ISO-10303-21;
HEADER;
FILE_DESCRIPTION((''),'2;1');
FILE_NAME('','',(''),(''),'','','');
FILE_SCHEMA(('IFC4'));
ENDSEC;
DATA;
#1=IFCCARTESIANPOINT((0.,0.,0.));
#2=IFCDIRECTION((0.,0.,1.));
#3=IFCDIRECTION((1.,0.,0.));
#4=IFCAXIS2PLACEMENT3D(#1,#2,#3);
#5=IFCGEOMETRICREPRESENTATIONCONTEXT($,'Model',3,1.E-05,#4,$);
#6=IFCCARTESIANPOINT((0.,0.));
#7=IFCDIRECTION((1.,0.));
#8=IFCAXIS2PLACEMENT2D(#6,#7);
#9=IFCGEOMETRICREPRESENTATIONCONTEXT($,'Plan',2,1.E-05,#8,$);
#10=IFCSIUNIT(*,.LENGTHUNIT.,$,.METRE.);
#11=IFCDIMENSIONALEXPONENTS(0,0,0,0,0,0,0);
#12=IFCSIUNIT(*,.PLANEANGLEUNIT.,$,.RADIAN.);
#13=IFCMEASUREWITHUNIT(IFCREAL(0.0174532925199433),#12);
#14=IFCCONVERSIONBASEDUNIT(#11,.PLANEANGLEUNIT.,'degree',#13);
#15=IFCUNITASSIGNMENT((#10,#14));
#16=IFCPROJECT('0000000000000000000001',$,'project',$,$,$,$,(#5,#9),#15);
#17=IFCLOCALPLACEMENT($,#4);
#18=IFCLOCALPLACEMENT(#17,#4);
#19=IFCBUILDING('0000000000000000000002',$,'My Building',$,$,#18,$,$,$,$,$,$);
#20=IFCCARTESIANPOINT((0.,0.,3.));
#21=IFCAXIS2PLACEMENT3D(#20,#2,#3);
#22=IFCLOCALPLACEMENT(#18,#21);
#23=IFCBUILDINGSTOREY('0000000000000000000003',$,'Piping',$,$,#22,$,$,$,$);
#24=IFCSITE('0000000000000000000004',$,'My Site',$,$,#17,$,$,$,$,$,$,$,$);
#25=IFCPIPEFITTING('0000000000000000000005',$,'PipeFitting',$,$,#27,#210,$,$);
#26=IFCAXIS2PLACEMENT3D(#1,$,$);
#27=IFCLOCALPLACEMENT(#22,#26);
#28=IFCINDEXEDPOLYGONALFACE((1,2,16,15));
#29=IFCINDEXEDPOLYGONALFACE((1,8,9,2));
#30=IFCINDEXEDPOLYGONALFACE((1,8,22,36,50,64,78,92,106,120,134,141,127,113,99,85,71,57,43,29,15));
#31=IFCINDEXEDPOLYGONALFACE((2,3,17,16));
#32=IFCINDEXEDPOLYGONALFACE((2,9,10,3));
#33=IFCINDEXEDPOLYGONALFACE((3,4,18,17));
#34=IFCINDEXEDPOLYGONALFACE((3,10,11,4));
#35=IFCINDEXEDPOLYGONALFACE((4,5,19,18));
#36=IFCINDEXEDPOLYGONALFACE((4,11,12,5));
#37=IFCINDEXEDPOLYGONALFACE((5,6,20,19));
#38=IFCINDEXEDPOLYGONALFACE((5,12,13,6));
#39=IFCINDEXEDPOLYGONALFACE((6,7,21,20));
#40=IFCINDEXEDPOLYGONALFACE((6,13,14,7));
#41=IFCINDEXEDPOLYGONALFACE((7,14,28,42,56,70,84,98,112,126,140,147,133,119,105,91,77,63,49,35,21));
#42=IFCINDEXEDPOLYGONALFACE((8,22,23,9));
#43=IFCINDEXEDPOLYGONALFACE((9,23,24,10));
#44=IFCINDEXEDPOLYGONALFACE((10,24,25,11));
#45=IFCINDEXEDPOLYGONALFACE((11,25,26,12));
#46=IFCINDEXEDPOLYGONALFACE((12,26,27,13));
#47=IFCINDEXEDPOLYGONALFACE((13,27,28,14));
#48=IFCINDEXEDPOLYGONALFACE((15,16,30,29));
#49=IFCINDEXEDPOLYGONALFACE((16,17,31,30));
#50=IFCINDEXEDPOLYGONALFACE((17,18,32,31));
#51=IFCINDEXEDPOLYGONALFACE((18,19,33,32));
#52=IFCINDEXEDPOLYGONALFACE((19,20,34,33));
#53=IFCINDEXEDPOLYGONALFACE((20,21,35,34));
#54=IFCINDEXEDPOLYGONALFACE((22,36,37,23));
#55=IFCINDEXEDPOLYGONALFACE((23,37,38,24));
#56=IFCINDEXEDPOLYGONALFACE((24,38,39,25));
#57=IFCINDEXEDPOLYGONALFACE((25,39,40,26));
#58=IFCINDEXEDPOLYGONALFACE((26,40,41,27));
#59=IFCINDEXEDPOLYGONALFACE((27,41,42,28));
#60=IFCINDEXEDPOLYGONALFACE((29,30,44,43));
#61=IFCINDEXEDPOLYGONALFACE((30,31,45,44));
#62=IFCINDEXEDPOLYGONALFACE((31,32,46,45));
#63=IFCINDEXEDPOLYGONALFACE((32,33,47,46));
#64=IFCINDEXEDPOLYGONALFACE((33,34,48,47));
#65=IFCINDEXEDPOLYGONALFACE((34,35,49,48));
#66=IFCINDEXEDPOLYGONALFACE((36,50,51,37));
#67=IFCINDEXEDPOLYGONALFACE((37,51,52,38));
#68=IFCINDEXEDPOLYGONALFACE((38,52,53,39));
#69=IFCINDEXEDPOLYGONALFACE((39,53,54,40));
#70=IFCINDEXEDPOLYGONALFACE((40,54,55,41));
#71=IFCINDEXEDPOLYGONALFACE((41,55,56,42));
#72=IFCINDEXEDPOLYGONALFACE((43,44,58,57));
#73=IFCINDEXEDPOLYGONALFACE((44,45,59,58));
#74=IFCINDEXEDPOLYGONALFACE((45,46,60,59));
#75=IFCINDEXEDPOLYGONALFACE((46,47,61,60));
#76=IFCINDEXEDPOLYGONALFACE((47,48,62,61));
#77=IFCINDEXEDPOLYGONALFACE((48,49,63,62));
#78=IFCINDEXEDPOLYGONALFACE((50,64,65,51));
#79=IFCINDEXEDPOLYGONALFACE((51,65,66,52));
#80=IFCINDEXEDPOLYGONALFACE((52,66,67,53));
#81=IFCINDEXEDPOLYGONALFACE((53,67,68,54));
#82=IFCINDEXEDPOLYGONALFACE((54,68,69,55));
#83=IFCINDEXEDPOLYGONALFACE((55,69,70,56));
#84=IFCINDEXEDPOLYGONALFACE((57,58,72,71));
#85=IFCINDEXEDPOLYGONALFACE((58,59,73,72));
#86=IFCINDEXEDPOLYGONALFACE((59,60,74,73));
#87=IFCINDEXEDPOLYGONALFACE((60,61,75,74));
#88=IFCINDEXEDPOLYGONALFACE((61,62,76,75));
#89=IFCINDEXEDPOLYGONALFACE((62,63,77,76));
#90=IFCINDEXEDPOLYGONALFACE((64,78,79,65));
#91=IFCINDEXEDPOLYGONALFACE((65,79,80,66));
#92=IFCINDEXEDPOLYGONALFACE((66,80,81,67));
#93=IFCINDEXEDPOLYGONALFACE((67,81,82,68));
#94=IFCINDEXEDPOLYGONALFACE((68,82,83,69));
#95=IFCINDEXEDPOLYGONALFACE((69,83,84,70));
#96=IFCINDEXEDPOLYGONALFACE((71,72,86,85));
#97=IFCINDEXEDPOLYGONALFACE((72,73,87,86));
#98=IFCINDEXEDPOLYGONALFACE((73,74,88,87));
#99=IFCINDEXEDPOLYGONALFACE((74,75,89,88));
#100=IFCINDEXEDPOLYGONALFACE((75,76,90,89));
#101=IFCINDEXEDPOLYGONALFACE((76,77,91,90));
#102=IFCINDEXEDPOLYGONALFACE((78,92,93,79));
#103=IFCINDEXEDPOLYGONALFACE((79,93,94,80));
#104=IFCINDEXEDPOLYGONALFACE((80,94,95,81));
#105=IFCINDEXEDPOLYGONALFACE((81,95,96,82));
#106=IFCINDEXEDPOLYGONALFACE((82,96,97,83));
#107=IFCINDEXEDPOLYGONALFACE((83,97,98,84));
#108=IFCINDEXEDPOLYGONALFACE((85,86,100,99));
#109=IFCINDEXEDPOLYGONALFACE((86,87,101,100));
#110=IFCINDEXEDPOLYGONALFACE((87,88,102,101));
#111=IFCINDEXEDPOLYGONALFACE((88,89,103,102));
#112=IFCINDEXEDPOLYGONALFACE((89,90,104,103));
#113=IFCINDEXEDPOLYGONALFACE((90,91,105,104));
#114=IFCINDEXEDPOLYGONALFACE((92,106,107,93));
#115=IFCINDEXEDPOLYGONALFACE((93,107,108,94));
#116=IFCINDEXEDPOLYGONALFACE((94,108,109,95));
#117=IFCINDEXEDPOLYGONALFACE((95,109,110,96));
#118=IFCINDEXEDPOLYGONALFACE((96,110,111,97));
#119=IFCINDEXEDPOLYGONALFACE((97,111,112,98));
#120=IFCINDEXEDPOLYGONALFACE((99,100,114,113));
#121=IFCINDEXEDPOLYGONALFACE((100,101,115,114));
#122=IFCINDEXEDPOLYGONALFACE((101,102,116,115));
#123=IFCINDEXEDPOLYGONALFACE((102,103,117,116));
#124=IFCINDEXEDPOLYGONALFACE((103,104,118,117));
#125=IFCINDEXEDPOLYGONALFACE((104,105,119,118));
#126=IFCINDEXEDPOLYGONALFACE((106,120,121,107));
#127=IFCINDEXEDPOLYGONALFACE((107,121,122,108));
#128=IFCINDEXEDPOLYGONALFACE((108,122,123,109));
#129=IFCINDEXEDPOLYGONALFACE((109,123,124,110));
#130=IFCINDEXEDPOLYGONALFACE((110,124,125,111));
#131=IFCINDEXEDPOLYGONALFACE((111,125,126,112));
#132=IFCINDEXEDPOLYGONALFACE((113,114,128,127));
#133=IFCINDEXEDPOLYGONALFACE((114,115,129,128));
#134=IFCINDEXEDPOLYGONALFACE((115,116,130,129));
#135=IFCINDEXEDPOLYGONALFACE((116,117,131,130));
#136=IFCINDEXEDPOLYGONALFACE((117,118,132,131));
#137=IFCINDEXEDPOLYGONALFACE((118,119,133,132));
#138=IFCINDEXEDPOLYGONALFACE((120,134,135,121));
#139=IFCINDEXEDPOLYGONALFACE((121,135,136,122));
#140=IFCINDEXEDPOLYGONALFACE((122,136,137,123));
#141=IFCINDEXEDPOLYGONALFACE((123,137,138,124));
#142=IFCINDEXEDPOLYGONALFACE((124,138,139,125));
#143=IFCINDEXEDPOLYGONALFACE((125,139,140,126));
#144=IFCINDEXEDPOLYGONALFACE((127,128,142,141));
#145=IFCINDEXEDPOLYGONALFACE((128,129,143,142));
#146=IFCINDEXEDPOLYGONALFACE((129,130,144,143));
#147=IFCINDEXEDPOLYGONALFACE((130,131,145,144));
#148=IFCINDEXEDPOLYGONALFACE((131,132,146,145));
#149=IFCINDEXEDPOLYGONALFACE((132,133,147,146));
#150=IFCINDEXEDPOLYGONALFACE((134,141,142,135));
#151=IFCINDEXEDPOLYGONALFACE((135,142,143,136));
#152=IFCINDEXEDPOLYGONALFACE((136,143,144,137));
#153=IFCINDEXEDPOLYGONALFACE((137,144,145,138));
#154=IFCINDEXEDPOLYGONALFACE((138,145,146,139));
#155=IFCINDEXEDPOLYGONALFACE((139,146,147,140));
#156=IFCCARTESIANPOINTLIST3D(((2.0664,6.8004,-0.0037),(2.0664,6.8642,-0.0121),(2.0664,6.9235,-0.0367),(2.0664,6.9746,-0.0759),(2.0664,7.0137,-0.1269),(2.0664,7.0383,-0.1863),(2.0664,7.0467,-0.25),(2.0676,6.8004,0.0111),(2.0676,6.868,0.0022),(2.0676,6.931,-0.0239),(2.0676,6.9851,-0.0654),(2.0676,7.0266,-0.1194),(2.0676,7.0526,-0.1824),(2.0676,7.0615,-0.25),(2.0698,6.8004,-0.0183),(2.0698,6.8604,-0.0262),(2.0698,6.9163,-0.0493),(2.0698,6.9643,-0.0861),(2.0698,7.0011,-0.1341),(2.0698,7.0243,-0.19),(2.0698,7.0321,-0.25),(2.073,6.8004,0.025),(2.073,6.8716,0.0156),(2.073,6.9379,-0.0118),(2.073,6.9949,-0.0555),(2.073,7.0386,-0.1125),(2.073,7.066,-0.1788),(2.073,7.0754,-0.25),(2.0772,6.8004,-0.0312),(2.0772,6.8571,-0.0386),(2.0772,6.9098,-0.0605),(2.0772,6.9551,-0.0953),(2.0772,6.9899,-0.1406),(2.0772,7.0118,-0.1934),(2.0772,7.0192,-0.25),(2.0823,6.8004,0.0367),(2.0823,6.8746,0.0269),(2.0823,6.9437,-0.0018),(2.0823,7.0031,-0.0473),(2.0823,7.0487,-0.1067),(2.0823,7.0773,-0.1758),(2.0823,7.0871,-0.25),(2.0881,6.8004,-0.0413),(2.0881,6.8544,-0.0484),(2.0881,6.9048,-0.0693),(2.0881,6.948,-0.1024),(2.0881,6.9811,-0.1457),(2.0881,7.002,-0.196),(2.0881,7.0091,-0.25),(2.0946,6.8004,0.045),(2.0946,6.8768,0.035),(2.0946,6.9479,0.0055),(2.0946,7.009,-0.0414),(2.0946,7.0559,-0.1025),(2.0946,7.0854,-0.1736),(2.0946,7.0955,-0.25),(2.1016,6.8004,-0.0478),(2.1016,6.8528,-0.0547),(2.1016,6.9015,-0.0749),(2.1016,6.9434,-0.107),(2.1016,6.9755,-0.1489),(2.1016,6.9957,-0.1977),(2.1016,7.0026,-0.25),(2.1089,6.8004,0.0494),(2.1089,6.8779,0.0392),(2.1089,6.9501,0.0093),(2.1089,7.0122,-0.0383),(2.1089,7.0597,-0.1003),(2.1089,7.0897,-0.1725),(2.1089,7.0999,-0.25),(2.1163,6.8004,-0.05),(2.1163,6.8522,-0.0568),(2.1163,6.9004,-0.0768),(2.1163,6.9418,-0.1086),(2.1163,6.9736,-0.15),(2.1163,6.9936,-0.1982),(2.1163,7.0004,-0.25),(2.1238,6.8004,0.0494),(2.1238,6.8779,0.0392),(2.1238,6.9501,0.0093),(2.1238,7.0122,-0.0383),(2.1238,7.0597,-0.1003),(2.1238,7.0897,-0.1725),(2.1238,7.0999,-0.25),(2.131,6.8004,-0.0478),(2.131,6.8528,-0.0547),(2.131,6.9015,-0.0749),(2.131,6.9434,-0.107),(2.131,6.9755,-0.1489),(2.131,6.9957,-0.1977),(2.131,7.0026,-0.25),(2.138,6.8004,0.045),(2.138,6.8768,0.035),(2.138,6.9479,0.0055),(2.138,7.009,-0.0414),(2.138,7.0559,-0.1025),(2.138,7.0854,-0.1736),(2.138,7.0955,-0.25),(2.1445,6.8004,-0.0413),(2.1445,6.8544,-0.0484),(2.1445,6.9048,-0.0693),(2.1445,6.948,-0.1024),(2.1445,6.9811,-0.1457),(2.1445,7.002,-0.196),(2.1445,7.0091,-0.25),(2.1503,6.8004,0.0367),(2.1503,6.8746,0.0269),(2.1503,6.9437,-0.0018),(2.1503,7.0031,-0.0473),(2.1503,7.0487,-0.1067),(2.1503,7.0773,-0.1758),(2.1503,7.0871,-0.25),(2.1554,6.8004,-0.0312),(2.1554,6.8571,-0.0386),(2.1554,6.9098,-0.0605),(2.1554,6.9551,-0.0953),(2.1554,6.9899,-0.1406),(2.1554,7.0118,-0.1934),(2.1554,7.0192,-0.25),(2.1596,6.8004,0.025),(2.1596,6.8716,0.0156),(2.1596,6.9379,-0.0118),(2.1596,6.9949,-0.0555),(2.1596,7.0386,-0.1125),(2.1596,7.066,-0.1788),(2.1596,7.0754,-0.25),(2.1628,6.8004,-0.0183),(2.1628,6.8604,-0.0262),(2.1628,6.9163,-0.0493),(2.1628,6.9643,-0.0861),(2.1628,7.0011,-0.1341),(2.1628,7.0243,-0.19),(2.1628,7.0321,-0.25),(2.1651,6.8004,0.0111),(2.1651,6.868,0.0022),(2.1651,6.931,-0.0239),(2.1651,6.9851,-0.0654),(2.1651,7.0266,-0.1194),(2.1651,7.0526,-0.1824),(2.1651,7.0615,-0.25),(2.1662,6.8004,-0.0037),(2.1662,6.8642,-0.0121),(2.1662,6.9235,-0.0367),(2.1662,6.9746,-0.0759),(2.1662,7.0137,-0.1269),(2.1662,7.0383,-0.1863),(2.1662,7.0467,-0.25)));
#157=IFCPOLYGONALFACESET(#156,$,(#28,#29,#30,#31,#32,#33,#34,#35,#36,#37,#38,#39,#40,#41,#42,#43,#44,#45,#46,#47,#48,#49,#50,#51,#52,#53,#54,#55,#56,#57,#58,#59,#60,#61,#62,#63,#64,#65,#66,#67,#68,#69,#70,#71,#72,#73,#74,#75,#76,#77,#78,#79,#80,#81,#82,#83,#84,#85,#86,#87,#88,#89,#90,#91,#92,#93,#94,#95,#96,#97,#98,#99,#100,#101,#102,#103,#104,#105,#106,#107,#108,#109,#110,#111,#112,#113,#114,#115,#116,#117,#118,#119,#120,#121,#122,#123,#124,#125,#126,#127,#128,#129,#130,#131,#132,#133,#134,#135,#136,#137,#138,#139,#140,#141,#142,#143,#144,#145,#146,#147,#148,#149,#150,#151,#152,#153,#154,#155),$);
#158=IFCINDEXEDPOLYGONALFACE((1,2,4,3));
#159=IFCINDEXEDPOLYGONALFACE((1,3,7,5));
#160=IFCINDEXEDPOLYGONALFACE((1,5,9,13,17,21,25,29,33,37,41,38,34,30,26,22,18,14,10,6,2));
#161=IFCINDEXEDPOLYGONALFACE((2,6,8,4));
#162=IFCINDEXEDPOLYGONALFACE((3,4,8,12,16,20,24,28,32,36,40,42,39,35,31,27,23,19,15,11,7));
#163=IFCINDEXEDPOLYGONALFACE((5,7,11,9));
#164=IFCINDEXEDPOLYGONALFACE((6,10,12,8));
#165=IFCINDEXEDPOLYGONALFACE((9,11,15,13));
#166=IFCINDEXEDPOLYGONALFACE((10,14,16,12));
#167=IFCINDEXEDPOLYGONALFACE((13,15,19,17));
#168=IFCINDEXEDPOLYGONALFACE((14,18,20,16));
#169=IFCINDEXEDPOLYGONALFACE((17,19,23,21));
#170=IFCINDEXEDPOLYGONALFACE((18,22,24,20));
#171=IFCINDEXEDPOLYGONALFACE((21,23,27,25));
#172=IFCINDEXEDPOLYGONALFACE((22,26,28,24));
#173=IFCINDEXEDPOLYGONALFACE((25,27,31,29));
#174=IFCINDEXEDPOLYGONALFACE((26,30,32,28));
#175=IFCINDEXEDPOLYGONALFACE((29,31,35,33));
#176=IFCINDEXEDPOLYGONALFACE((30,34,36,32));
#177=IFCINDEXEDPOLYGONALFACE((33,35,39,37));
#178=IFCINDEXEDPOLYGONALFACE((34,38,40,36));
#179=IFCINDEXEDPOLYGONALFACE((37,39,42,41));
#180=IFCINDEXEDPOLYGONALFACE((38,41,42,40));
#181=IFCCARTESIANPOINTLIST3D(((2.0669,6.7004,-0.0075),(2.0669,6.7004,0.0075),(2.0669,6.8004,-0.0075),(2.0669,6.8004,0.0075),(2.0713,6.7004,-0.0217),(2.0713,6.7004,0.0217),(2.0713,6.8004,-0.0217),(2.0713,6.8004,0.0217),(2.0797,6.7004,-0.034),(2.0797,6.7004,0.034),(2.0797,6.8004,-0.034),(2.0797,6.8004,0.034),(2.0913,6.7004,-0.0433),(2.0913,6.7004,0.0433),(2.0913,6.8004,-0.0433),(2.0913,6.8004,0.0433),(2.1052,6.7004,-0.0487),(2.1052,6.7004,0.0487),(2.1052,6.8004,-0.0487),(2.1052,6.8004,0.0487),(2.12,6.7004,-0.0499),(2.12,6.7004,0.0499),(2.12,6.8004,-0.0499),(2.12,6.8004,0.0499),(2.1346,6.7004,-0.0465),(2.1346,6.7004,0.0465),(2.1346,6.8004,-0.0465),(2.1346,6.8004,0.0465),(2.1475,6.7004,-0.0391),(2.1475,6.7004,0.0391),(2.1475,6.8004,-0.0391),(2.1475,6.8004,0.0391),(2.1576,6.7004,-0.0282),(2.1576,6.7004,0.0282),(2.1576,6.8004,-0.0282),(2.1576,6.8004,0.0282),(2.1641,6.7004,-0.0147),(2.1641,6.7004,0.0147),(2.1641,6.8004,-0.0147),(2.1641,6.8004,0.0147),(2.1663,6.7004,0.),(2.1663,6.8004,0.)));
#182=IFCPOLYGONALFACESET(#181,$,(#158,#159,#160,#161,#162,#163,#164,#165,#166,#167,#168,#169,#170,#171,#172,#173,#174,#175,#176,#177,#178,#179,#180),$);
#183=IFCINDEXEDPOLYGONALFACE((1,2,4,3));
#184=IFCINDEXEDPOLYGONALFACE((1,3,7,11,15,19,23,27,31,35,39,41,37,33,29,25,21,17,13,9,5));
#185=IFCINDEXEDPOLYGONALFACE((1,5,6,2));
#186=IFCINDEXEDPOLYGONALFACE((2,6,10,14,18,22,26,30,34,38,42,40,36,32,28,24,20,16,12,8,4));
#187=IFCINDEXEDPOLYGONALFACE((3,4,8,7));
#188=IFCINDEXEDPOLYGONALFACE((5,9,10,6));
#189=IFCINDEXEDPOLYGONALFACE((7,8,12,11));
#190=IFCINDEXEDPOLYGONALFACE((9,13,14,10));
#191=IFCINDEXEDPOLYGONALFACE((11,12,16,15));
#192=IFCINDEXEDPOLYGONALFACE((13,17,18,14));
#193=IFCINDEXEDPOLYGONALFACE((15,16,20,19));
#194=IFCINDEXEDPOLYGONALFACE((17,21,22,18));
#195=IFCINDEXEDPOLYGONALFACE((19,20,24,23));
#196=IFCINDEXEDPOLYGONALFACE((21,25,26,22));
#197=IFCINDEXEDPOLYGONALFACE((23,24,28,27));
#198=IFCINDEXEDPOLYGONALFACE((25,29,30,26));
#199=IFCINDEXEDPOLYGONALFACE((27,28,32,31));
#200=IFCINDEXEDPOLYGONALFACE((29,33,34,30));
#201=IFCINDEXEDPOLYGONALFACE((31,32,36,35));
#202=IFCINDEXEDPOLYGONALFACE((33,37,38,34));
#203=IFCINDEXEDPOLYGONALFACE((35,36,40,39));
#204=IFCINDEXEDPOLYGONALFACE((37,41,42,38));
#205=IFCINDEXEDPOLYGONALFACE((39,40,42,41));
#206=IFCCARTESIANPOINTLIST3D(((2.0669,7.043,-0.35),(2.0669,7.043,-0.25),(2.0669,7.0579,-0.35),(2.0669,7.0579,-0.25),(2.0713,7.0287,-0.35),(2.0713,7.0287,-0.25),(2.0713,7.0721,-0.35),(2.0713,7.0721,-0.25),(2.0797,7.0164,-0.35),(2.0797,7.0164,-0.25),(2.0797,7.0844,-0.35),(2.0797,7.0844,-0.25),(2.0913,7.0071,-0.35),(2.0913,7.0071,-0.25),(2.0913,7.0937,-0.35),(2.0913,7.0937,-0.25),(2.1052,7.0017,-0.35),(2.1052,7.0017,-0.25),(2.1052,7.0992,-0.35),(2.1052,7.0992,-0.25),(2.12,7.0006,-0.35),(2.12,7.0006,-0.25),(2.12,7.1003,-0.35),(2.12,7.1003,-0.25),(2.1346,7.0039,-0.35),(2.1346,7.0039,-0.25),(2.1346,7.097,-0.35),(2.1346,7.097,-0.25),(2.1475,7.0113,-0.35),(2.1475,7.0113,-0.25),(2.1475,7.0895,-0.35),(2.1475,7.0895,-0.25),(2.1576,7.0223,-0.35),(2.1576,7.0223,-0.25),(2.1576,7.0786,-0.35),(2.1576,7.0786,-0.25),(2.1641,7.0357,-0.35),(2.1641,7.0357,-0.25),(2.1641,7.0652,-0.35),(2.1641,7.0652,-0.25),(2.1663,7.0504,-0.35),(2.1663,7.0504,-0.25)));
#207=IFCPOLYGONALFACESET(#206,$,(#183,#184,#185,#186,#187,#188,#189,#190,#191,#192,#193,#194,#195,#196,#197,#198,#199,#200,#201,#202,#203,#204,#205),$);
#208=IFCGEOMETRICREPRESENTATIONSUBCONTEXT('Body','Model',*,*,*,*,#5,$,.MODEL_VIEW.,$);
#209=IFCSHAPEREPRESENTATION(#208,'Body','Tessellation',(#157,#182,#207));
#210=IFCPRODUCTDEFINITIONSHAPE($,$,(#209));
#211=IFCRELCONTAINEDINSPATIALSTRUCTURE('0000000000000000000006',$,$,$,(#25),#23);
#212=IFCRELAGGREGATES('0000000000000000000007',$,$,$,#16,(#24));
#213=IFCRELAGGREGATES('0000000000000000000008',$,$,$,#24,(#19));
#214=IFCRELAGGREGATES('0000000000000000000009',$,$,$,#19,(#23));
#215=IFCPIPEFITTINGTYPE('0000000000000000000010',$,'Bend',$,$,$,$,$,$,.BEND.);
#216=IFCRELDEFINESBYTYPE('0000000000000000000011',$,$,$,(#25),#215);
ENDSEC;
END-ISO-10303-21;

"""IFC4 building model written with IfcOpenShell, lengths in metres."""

from ifc_helpers import new_model, entity, si_unit, converted_unit, frame, origin_with_axes, origin_2d_with_axis, place, context, subcontext, project, spatial, circle, extrude, source, transform, mapped, type_object, type_shapes, element, save


model = new_model("IFC4")

# Units and contexts
model_context = context("Model", 3, precision=1e-05, world=origin_with_axes())
plan_context = context("Plan", 2, precision=1e-05, world=origin_2d_with_axis())
body_context = subcontext(model_context, "Body", "Model", "MODEL_VIEW")
ifc_project = project(units=[si_unit("LENGTHUNIT", "METRE"), converted_unit("PLANEANGLEUNIT", "degree", entity("IfcReal", 0.0174532925199433), si_unit("PLANEANGLEUNIT", "RADIAN"), dimensions=[0, 0, 0, 0, 0, 0, 0])], contexts=[model_context, plan_context])

# Site, building, storey
site_placement = place(None, origin_with_axes())
site = spatial("IfcSite", under=ifc_project, at=site_placement, Name="My Site")
building_placement = place(site_placement, origin_with_axes())
building = spatial("IfcBuilding", under=site, at=building_placement, Name="My Building")
storey_placement = place(building_placement, frame((0.0, 0.0, 3.0), z_axis=(0.0, 0.0, 1.0), x_axis=(1.0, 0.0, 0.0)))
storey = spatial("IfcBuildingStorey", under=building, at=storey_placement, Name="Piping")

# Pipe fitting
pipe_fitting_type = type_object("IfcPipeFittingType", Name="Bend", PredefinedType="BEND")
shared_shape = source(origin_with_axes(), body_context, "Body", "SolidModel", [
    entity("IfcSweptDiskSolid", entity("IfcIndexedPolyCurve", entity("IfcCartesianPointList3D", [[0.0, 0.0, -0.1], [0.0, -0.0732, -0.2768], [0.0, -0.25, -0.35]]), [entity("IfcArcIndex", [1, 2, 3])]), 0.05),
    extrude(circle(Radius=0.05), origin_with_axes(), (0.0, 0.0, -1.0), 0.1),
    extrude(circle(Radius=0.05), frame((0.0, -0.25, -0.35), z_axis=(0.0, -1.0, 0.0), x_axis=(1.0, 0.0, 0.0)), (0.0, 0.0, 1.0), 0.1),
])
type_shapes(pipe_fitting_type, [shared_shape])
for number, where, z_axis, x_axis, name in (
    (1, (2.1163, 6.7004, 0.0), (0.0, -1.0, 0.0), (1.0, 0.0, 0.0), "PipeFitting"),
):
    element("IfcPipeFitting", number, at=place(storey_placement, frame(where, z_axis=z_axis, x_axis=x_axis)), inside=storey, type_object=pipe_fitting_type, Name=name, context=body_context, shape_type="MappedRepresentation", body=[
        mapped(shared_shape, transform((0.0, 0.0, 0.0), x_axis=(1.0, 0.0, 0.0), y_axis=(0.0, 1.0, 0.0), z_axis=(0.0, 0.0, 1.0), scale=1.0)),
    ])

save(model, "model.ifc")
